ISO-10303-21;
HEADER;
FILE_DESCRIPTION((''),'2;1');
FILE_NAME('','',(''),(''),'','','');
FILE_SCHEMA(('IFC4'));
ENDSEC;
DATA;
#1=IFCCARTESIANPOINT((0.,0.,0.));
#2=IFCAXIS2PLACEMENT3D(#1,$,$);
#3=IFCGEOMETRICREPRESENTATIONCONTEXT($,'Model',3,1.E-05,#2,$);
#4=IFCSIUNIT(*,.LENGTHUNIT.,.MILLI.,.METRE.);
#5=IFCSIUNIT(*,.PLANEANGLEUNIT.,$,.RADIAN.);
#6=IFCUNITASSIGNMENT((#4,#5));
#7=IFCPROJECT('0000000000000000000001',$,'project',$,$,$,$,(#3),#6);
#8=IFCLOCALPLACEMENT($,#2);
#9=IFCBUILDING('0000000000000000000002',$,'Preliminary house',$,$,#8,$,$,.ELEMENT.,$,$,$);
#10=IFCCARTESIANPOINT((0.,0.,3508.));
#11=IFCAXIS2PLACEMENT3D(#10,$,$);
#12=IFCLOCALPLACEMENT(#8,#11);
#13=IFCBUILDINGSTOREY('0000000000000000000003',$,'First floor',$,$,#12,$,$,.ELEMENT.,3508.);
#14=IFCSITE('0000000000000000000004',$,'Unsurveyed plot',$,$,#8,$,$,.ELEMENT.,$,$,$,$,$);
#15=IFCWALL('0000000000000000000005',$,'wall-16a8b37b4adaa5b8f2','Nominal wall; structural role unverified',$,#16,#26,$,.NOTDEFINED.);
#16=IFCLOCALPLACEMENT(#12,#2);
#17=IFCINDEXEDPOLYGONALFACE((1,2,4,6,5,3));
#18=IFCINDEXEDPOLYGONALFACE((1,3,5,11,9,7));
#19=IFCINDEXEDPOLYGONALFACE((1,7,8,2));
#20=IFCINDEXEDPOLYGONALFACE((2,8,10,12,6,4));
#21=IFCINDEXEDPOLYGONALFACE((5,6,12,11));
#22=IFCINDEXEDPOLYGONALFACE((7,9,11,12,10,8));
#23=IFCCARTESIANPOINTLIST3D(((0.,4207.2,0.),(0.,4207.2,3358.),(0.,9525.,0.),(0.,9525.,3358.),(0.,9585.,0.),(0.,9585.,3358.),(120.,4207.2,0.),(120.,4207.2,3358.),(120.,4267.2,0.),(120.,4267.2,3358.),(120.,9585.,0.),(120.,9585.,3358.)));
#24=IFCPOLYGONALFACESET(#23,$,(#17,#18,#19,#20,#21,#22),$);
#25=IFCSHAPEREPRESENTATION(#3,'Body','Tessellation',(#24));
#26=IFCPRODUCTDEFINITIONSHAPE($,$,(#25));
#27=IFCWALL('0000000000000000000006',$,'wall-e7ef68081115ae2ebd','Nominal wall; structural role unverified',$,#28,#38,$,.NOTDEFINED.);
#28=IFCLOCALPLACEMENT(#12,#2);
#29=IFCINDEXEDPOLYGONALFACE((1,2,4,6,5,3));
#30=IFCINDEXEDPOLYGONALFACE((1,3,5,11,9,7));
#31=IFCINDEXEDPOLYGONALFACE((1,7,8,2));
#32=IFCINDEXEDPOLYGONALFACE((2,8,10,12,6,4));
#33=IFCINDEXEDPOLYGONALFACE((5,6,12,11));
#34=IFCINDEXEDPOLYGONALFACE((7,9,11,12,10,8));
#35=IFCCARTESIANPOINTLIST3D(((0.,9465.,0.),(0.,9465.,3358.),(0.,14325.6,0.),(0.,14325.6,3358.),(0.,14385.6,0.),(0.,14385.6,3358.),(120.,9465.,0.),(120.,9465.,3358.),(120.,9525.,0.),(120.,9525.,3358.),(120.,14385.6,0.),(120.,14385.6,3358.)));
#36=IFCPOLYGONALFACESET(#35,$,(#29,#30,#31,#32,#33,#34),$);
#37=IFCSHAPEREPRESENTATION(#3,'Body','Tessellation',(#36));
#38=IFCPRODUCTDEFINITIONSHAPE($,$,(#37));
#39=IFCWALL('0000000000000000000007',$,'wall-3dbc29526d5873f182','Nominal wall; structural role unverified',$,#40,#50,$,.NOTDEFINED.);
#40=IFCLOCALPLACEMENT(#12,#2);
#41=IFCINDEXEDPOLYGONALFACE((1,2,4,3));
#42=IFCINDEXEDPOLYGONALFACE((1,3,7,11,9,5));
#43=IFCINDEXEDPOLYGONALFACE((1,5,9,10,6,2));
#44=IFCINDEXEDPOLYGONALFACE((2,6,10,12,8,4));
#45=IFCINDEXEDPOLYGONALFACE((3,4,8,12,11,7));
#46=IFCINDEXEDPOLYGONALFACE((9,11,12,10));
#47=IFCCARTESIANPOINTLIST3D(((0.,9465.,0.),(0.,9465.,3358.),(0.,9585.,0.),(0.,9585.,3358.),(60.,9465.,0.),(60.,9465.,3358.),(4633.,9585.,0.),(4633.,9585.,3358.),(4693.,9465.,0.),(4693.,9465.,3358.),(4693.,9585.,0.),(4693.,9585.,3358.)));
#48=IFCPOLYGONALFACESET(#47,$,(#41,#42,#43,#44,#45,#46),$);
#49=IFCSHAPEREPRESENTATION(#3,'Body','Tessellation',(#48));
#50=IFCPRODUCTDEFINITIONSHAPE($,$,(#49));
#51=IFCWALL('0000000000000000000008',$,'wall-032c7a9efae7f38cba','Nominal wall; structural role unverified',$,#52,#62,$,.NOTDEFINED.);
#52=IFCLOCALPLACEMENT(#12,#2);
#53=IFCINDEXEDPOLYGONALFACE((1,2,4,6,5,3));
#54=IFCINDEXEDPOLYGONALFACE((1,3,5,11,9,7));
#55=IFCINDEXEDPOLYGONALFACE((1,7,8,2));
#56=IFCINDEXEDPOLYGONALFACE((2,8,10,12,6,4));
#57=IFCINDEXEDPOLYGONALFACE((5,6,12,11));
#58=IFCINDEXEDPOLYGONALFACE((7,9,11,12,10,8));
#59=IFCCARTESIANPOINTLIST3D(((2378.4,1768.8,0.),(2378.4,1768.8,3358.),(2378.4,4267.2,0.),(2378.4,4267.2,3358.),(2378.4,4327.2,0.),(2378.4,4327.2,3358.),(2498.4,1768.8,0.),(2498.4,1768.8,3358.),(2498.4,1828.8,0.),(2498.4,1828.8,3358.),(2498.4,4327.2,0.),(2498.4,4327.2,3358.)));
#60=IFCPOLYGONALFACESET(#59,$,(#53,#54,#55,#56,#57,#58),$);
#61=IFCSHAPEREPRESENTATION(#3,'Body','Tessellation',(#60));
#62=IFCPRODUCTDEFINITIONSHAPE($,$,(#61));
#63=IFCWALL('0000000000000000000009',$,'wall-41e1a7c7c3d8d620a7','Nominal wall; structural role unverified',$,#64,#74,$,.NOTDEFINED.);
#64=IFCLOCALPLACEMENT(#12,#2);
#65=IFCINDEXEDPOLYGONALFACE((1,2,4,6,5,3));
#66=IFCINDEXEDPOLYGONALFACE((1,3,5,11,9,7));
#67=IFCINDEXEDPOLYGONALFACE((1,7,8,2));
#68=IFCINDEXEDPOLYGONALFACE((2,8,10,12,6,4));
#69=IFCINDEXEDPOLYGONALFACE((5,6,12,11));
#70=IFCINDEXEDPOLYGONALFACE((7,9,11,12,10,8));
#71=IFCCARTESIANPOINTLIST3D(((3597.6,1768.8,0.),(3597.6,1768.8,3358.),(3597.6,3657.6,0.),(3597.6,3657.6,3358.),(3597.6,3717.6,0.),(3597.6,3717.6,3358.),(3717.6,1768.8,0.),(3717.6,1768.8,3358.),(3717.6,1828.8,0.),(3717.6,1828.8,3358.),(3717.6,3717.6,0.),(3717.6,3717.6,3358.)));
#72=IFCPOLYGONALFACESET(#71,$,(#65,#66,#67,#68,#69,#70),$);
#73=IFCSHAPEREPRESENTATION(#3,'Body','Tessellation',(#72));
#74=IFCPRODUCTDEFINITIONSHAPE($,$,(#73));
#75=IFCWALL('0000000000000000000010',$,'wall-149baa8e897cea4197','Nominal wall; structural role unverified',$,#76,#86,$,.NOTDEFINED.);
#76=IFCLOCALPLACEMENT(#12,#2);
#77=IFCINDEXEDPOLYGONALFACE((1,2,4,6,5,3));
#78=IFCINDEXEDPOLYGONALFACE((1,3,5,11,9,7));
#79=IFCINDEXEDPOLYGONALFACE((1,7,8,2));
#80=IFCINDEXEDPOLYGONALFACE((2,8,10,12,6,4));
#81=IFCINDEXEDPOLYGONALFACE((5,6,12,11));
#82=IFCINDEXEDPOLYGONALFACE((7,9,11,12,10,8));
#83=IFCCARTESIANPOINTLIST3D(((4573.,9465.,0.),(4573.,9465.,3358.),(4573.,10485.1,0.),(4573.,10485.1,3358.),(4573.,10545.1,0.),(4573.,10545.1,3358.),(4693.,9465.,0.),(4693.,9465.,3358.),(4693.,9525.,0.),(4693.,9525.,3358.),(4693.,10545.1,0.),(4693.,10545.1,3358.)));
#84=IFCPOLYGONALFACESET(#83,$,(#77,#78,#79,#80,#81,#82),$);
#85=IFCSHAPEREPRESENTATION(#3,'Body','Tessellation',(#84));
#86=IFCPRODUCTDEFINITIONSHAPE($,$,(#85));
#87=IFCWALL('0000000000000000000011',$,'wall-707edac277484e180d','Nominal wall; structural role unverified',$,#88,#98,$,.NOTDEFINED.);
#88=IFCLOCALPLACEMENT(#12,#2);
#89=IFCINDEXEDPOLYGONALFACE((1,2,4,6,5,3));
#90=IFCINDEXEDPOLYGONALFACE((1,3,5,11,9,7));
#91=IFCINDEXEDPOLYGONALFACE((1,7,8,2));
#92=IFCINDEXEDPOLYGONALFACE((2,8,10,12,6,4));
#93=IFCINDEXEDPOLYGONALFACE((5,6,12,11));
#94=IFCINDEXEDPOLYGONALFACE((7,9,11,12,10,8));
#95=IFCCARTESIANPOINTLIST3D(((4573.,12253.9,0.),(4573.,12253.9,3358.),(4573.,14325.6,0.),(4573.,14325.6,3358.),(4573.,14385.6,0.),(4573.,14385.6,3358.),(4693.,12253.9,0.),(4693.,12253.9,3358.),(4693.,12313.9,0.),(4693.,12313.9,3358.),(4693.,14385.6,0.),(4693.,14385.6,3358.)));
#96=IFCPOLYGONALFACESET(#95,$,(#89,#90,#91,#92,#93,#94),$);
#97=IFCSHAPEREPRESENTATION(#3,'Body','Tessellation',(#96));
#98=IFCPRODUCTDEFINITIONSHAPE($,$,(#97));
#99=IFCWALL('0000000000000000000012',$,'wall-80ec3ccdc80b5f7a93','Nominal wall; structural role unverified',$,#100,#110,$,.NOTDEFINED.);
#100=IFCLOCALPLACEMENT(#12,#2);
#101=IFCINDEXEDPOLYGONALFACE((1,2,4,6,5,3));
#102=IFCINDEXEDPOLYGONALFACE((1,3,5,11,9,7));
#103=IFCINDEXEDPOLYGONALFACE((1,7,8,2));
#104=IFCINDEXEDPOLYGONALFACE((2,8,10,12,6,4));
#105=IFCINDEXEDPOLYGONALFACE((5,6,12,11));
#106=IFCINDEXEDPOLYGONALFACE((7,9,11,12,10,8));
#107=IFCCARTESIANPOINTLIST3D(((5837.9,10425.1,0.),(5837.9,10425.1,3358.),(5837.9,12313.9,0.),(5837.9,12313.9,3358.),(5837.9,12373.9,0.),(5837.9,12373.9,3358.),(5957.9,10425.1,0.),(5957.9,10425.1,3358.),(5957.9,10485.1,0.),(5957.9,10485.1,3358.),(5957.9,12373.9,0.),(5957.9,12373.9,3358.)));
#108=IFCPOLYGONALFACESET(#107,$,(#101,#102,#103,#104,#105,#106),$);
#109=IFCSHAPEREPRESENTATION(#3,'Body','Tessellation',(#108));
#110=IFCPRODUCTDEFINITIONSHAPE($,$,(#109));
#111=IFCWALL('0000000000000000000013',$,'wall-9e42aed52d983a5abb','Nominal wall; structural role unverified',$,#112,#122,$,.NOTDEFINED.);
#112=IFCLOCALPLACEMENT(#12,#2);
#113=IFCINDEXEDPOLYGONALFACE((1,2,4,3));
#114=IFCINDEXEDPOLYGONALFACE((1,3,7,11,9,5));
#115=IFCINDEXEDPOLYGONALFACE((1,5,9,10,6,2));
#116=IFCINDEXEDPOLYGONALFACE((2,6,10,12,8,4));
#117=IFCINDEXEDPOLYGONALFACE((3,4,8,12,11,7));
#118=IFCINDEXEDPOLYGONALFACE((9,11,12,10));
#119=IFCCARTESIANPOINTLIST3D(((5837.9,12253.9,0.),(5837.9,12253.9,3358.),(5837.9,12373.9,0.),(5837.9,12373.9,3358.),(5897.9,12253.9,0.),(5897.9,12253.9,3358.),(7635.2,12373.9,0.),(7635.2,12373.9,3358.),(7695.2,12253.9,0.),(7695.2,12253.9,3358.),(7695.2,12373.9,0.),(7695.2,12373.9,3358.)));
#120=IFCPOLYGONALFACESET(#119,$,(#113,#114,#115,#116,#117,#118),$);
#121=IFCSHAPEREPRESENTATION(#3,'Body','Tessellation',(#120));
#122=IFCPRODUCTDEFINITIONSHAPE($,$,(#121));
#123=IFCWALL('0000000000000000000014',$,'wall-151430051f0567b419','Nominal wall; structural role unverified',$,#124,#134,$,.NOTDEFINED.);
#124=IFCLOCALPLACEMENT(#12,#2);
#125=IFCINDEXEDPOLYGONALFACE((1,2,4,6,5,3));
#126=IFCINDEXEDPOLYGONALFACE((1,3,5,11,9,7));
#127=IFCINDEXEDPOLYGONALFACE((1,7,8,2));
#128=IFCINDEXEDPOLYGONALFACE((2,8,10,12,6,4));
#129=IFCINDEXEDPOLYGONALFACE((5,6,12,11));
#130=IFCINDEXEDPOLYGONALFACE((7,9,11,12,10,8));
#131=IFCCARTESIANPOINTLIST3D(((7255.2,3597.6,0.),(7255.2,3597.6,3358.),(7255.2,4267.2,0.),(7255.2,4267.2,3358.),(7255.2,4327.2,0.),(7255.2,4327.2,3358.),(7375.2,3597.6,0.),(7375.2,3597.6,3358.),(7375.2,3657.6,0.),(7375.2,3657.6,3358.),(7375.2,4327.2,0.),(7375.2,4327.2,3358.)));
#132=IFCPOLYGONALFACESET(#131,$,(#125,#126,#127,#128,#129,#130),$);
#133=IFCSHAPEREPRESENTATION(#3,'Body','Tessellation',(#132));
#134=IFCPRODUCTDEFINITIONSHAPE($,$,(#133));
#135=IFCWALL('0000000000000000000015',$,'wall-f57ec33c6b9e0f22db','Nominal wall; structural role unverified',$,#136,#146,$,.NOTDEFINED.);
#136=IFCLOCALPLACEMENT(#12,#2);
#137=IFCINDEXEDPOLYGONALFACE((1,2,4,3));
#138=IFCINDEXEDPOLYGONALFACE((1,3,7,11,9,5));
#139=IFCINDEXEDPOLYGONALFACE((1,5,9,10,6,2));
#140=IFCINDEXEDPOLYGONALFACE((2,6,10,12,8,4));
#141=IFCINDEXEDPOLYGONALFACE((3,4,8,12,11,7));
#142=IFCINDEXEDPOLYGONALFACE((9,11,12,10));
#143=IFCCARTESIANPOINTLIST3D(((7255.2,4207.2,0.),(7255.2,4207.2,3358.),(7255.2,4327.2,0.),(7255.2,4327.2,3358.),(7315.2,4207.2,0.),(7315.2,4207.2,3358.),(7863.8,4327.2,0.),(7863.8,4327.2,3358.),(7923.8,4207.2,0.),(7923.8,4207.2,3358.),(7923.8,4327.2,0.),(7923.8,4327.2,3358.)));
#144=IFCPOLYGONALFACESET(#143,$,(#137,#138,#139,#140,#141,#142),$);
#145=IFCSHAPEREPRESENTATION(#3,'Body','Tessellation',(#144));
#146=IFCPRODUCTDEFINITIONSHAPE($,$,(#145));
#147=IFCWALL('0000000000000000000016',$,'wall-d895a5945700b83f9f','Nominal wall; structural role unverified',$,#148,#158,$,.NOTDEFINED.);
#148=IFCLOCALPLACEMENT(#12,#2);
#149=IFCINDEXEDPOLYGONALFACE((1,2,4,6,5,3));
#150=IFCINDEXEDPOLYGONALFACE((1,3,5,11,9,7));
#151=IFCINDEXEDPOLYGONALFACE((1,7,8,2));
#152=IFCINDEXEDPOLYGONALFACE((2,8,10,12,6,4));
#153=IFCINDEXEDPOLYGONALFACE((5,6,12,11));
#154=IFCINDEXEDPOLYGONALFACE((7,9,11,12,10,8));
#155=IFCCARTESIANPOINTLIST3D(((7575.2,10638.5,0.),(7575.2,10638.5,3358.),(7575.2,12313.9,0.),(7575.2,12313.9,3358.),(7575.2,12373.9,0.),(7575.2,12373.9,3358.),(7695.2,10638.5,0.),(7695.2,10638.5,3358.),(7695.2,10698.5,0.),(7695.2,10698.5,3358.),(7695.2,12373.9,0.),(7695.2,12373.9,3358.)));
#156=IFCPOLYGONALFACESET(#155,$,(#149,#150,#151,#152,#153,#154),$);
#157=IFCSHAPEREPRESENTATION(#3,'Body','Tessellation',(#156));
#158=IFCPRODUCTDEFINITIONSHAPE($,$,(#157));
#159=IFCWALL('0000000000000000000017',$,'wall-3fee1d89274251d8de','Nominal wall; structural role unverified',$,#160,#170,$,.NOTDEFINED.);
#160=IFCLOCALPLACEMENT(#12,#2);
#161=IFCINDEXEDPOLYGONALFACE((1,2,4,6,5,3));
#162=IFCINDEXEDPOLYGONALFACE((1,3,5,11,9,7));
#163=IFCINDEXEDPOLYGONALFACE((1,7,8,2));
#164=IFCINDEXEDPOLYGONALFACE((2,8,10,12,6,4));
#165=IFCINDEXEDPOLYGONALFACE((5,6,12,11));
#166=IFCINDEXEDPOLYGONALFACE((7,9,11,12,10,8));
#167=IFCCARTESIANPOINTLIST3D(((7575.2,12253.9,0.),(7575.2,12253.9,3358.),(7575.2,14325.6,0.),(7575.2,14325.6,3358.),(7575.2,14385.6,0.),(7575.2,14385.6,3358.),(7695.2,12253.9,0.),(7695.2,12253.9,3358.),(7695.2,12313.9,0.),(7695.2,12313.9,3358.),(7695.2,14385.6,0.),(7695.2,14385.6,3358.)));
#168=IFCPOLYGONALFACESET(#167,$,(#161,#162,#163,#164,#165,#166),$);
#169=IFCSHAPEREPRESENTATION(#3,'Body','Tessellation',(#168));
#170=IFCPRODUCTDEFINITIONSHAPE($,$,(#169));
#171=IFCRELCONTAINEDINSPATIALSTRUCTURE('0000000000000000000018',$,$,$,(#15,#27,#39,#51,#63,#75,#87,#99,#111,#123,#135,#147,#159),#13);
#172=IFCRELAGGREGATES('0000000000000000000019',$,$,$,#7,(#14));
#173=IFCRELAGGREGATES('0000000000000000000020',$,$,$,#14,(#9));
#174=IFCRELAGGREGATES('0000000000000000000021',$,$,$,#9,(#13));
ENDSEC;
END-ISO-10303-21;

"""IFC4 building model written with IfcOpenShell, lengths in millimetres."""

from ifc_helpers import new_model, si_unit, frame, origin, place, context, project, spatial, polyline, outline, extrude, element, save


model = new_model("IFC4")

# Units and contexts
model_context = context("Model", 3, precision=1e-05, world=origin())
ifc_project = project(units=[si_unit("LENGTHUNIT", "METRE", prefix="MILLI"), si_unit("PLANEANGLEUNIT", "RADIAN")], contexts=[model_context])

# Site, building, storey
placement_1 = place(None, origin())
site = spatial("IfcSite", under=ifc_project, at=placement_1, Name="Unsurveyed plot", CompositionType="ELEMENT")
building = spatial("IfcBuilding", under=site, at=placement_1, Name="Preliminary house", CompositionType="ELEMENT")
placement_2 = place(placement_1, frame((0.0, 0.0, 3508.0)))
storey = spatial("IfcBuildingStorey", under=building, at=placement_2, Name="First floor", CompositionType="ELEMENT", Elevation=3508.0)

# Wall
element("IfcWall", 1, at=placement_2, inside=storey, Name="wall-16a8b37b4adaa5b8f2", Description="Nominal wall; structural role unverified", PredefinedType="NOTDEFINED", context=model_context, shape_type="SweptSolid", body=[
    extrude(outline(polyline([(0.0, 9525.0), (0.0, 9585.0), (120.0, 9585.0), (120.0, 4267.2), (120.0, 4207.2), (0.0, 4207.2), (0.0, 9525.0)])), origin(), (0.0, 0.0, 1.0), 3358.0),
])

# Walls
element("IfcWall", 2, at=placement_2, inside=storey, Name="wall-e7ef68081115ae2ebd", Description="Nominal wall; structural role unverified", PredefinedType="NOTDEFINED", context=model_context, shape_type="SweptSolid", body=[
    extrude(outline(polyline([(0.0, 14325.6), (0.0, 14385.6), (120.0, 14385.6), (120.0, 9525.0), (120.0, 9465.0), (0.0, 9465.0), (0.0, 14325.6)])), origin(), (0.0, 0.0, 1.0), 3358.0),
])
element("IfcWall", 3, at=placement_2, inside=storey, Name="wall-3dbc29526d5873f182", Description="Nominal wall; structural role unverified", PredefinedType="NOTDEFINED", context=model_context, shape_type="SweptSolid", body=[
    extrude(outline(polyline([(4633.0, 9585.0), (4693.0, 9585.0), (4693.0, 9465.0), (60.0, 9465.0), (0.0, 9465.0), (0.0, 9585.0), (4633.0, 9585.0)])), origin(), (0.0, 0.0, 1.0), 3358.0),
])

# Wall
element("IfcWall", 4, at=placement_2, inside=storey, Name="wall-032c7a9efae7f38cba", Description="Nominal wall; structural role unverified", PredefinedType="NOTDEFINED", context=model_context, shape_type="SweptSolid", body=[
    extrude(outline(polyline([(2378.4, 4267.2), (2378.4, 4327.2), (2498.4, 4327.2), (2498.4, 1828.8), (2498.4, 1768.8), (2378.4, 1768.8), (2378.4, 4267.2)])), origin(), (0.0, 0.0, 1.0), 3358.0),
])

# Wall
element("IfcWall", 5, at=placement_2, inside=storey, Name="wall-41e1a7c7c3d8d620a7", Description="Nominal wall; structural role unverified", PredefinedType="NOTDEFINED", context=model_context, shape_type="SweptSolid", body=[
    extrude(outline(polyline([(3597.6, 3657.6), (3597.6, 3717.6), (3717.6, 3717.6), (3717.6, 1828.8), (3717.6, 1768.8), (3597.6, 1768.8), (3597.6, 3657.6)])), origin(), (0.0, 0.0, 1.0), 3358.0),
])

# Wall
element("IfcWall", 6, at=placement_2, inside=storey, Name="wall-149baa8e897cea4197", Description="Nominal wall; structural role unverified", PredefinedType="NOTDEFINED", context=model_context, shape_type="SweptSolid", body=[
    extrude(outline(polyline([(4573.0, 10485.1), (4573.0, 10545.1), (4693.0, 10545.1), (4693.0, 9525.0), (4693.0, 9465.0), (4573.0, 9465.0), (4573.0, 10485.1)])), origin(), (0.0, 0.0, 1.0), 3358.0),
])

# Wall
element("IfcWall", 7, at=placement_2, inside=storey, Name="wall-707edac277484e180d", Description="Nominal wall; structural role unverified", PredefinedType="NOTDEFINED", context=model_context, shape_type="SweptSolid", body=[
    extrude(outline(polyline([(4573.0, 14325.6), (4573.0, 14385.6), (4693.0, 14385.6), (4693.0, 12313.9), (4693.0, 12253.9), (4573.0, 12253.9), (4573.0, 14325.6)])), origin(), (0.0, 0.0, 1.0), 3358.0),
])

# Walls
element("IfcWall", 8, at=placement_2, inside=storey, Name="wall-80ec3ccdc80b5f7a93", Description="Nominal wall; structural role unverified", PredefinedType="NOTDEFINED", context=model_context, shape_type="SweptSolid", body=[
    extrude(outline(polyline([(5837.9, 12313.9), (5837.9, 12373.9), (5957.9, 12373.9), (5957.9, 10485.1), (5957.9, 10425.1), (5837.9, 10425.1), (5837.9, 12313.9)])), origin(), (0.0, 0.0, 1.0), 3358.0),
])
element("IfcWall", 9, at=placement_2, inside=storey, Name="wall-9e42aed52d983a5abb", Description="Nominal wall; structural role unverified", PredefinedType="NOTDEFINED", context=model_context, shape_type="SweptSolid", body=[
    extrude(outline(polyline([(7635.2, 12373.9), (7695.2, 12373.9), (7695.2, 12253.9), (5897.9, 12253.9), (5837.9, 12253.9), (5837.9, 12373.9), (7635.2, 12373.9)])), origin(), (0.0, 0.0, 1.0), 3358.0),
])
element("IfcWall", 10, at=placement_2, inside=storey, Name="wall-151430051f0567b419", Description="Nominal wall; structural role unverified", PredefinedType="NOTDEFINED", context=model_context, shape_type="SweptSolid", body=[
    extrude(outline(polyline([(7255.2, 4267.2), (7255.2, 4327.2), (7375.2, 4327.2), (7375.2, 3657.6), (7375.2, 3597.6), (7255.2, 3597.6), (7255.2, 4267.2)])), origin(), (0.0, 0.0, 1.0), 3358.0),
])

# Walls
element("IfcWall", 11, at=placement_2, inside=storey, Name="wall-f57ec33c6b9e0f22db", Description="Nominal wall; structural role unverified", PredefinedType="NOTDEFINED", context=model_context, shape_type="SweptSolid", body=[
    extrude(outline(polyline([(7863.8, 4327.2), (7923.8, 4327.2), (7923.8, 4207.2), (7315.2, 4207.2), (7255.2, 4207.2), (7255.2, 4327.2), (7863.8, 4327.2)])), origin(), (0.0, 0.0, 1.0), 3358.0),
])
element("IfcWall", 12, at=placement_2, inside=storey, Name="wall-d895a5945700b83f9f", Description="Nominal wall; structural role unverified", PredefinedType="NOTDEFINED", context=model_context, shape_type="SweptSolid", body=[
    extrude(outline(polyline([(7575.2, 12313.9), (7575.2, 12373.9), (7695.2, 12373.9), (7695.2, 10698.5), (7695.2, 10638.5), (7575.2, 10638.5), (7575.2, 12313.9)])), origin(), (0.0, 0.0, 1.0), 3358.0),
])

# Wall
element("IfcWall", 13, at=placement_2, inside=storey, Name="wall-3fee1d89274251d8de", Description="Nominal wall; structural role unverified", PredefinedType="NOTDEFINED", context=model_context, shape_type="SweptSolid", body=[
    extrude(outline(polyline([(7575.2, 14325.6), (7575.2, 14385.6), (7695.2, 14385.6), (7695.2, 12313.9), (7695.2, 12253.9), (7575.2, 12253.9), (7575.2, 14325.6)])), origin(), (0.0, 0.0, 1.0), 3358.0),
])

save(model, "model.ifc")
